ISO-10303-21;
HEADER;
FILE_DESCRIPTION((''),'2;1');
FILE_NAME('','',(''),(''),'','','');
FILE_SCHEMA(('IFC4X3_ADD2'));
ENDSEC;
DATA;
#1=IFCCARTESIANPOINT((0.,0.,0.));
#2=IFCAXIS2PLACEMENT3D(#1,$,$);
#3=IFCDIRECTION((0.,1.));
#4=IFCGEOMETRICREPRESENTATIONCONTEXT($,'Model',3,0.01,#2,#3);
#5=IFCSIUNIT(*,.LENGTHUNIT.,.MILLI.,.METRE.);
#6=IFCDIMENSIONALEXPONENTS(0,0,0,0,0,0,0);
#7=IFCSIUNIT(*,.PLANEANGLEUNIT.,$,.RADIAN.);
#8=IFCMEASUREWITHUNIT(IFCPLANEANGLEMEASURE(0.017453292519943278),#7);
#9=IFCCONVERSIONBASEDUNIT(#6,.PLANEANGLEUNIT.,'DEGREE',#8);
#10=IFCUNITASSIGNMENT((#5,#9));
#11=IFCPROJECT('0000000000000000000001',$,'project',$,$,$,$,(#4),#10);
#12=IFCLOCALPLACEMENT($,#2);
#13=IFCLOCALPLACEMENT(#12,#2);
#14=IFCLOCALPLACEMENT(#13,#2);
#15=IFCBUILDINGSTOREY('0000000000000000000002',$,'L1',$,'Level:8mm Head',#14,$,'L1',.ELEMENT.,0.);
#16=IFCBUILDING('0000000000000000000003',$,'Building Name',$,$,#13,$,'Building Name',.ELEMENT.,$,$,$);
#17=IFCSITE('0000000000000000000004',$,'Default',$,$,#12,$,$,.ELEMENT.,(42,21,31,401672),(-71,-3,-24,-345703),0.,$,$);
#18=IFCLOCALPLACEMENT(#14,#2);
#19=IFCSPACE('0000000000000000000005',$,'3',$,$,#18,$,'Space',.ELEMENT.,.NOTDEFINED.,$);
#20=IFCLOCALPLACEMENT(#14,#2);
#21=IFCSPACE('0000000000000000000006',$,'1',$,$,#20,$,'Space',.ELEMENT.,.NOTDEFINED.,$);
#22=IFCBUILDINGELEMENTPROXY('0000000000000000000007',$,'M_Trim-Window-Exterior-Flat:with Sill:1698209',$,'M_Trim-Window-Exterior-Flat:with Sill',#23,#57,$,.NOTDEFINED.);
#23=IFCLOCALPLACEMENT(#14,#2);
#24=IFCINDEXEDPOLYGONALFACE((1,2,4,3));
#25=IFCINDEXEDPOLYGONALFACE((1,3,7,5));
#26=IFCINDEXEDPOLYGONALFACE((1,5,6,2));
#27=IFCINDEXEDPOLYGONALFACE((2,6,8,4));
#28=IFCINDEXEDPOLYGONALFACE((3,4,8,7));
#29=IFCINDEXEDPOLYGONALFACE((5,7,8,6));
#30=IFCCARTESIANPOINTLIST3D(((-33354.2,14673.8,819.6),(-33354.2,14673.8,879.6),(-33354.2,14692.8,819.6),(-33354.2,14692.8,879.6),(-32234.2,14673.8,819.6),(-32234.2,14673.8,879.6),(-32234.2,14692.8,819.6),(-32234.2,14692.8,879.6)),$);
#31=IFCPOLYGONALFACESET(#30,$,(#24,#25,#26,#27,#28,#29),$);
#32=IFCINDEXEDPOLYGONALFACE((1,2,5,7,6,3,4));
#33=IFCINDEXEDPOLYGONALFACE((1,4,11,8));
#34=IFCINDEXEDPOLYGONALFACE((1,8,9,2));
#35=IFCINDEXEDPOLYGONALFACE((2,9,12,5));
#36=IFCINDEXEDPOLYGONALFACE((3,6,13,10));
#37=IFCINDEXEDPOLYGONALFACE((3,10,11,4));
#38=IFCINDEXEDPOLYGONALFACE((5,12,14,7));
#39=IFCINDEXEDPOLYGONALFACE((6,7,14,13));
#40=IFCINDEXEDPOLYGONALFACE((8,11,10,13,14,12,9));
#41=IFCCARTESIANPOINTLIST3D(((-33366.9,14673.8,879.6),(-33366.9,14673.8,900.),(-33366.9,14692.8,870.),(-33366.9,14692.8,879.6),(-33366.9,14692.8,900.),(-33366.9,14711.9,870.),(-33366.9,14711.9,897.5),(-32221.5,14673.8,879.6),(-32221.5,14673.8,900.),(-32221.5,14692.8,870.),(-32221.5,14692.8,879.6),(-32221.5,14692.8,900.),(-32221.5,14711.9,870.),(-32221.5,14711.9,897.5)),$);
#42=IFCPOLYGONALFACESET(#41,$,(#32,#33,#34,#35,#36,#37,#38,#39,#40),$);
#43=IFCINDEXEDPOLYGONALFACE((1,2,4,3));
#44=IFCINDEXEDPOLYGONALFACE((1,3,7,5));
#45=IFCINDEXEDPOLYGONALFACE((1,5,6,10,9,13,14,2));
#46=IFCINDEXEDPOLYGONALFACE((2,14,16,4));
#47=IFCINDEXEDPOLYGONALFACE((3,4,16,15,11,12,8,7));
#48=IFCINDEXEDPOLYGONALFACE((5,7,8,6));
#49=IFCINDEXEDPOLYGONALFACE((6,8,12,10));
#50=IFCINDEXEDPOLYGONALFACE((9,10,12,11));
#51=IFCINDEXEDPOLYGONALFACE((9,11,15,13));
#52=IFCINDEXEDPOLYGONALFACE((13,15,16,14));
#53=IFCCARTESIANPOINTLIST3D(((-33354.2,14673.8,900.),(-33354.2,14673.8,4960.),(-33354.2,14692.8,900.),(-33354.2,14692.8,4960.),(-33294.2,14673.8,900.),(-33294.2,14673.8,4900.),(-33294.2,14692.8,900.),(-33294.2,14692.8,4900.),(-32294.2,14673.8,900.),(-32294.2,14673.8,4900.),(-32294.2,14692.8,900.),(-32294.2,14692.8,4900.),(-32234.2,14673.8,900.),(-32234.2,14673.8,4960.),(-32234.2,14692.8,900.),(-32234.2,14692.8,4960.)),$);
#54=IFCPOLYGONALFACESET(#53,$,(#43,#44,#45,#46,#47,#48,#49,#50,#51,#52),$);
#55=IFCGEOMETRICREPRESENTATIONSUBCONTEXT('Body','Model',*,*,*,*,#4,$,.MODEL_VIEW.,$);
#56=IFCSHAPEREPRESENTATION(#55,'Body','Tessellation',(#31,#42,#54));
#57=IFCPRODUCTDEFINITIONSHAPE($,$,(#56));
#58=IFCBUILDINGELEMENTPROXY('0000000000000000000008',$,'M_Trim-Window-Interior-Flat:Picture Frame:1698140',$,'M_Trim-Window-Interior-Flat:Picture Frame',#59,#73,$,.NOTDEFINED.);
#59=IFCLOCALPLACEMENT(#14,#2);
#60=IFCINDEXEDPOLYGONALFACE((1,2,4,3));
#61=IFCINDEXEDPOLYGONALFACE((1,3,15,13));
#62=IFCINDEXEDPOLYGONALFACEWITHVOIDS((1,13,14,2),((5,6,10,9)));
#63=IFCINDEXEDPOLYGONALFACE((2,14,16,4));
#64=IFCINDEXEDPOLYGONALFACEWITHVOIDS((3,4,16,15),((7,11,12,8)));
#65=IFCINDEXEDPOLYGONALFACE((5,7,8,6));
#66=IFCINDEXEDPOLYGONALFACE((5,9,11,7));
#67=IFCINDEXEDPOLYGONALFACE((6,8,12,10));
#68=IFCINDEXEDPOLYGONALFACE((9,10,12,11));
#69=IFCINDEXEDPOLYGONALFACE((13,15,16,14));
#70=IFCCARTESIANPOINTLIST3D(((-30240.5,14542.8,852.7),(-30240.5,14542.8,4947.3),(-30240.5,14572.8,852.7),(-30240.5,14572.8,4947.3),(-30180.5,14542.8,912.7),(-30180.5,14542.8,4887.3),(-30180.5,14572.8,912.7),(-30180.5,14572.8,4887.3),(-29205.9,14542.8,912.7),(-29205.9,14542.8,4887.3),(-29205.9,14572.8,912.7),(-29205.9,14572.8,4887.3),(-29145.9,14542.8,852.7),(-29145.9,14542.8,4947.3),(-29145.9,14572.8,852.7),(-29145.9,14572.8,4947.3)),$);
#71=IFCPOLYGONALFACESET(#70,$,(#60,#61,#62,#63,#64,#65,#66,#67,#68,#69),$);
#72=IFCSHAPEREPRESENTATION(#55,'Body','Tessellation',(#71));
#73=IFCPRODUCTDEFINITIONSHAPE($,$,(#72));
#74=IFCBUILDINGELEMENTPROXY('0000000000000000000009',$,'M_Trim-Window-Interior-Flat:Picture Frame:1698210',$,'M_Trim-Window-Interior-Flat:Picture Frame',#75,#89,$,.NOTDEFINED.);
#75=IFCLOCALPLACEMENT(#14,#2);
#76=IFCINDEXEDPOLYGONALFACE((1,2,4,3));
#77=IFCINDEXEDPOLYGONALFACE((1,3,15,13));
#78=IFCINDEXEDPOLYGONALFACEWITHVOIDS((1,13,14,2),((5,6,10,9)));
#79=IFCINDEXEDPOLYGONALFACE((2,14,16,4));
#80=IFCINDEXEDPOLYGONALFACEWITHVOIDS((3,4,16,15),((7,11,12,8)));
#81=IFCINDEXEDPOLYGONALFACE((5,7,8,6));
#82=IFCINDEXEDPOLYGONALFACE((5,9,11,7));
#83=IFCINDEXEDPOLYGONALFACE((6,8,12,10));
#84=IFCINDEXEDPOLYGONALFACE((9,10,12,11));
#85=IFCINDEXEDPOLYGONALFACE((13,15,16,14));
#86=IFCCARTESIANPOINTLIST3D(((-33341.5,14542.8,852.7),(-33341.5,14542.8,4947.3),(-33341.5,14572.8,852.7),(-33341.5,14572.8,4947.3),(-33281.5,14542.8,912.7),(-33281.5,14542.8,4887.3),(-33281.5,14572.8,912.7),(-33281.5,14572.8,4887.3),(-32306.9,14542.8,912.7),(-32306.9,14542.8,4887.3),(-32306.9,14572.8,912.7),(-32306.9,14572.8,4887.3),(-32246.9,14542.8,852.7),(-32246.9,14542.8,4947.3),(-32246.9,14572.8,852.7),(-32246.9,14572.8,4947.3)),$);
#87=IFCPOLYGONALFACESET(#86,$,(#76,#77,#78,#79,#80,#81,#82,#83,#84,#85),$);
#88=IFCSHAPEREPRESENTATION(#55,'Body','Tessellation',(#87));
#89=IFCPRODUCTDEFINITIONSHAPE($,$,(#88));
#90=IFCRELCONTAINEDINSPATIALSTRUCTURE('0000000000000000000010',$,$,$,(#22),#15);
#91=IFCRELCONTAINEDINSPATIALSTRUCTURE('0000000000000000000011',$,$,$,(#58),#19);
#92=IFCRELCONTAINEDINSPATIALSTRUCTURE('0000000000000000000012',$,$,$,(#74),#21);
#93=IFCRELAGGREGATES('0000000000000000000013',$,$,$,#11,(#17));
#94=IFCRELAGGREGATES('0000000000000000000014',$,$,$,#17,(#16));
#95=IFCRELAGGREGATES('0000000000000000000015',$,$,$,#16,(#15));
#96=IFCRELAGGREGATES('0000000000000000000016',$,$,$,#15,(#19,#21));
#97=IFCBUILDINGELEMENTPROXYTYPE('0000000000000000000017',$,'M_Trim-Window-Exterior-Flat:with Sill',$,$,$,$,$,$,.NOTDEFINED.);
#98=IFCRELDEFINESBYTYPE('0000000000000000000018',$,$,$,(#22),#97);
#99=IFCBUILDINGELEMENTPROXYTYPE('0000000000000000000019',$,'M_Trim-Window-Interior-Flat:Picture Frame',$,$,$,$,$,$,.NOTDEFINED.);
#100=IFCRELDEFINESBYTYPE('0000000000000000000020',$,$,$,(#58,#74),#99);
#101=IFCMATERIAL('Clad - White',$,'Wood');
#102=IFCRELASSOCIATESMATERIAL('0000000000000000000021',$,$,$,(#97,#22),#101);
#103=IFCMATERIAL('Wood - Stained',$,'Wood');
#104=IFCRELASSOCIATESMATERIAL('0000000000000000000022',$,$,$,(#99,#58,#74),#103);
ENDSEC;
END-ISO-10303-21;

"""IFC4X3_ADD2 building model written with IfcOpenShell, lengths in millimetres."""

from ifc_helpers import new_model, entity, si_unit, converted_unit, direction, frame, frame_2d, origin, place, context, subcontext, project, spatial, polyline, rectangle, outline, extrude, source, transform, mapped, material, type_object, type_shapes, element, save


model = new_model("IFC4X3_ADD2")

# Units and contexts
model_context = context("Model", 3, precision=0.01, world=origin(), true_north=direction((0.0, 1.0)))
body_context = subcontext(model_context, "Body", "Model", "MODEL_VIEW")
ifc_project = project(units=[si_unit("LENGTHUNIT", "METRE", prefix="MILLI"), converted_unit("PLANEANGLEUNIT", "DEGREE", entity("IfcPlaneAngleMeasure", 0.017453292519943278), si_unit("PLANEANGLEUNIT", "RADIAN"), dimensions=[0, 0, 0, 0, 0, 0, 0])], contexts=[model_context])

# Site, building, storey
site_placement = place(None, origin())
site = spatial("IfcSite", under=ifc_project, at=site_placement, Name="Default", CompositionType="ELEMENT", RefLatitude=(42, 21, 31, 401672), RefLongitude=(-71, -3, -24, -345703), RefElevation=0.0)
building_placement = place(site_placement, origin())
building = spatial("IfcBuilding", under=site, at=building_placement, Name="Building Name", LongName="Building Name", CompositionType="ELEMENT")
storey_placement = place(building_placement, origin())
storey = spatial("IfcBuildingStorey", under=building, at=storey_placement, Name="L1", ObjectType="Level:8mm Head", LongName="L1", CompositionType="ELEMENT", Elevation=0.0)

# Building element proxy
ifc_material_1 = material(Name="Clad - White", Category="Wood")
ifc_material_2 = material(Name="Wood - Stained", Category="Wood")
building_element_proxy_type_1 = type_object("IfcBuildingElementProxyType", Name="M_Trim-Window-Exterior-Flat:with Sill", PredefinedType="NOTDEFINED", material=ifc_material_1)
shared_shape_1 = source(origin(), body_context, "Body", "SweptSolid", [
    extrude(rectangle(XDim=1120.0, YDim=60.0, at=frame_2d((0.0, 0.0), x_axis=(1.0, 0.0))), frame((0.0, -4050.4, 0.0), z_axis=(0.0, 0.0, 1.0), x_axis=(-1.0, 0.0, 0.0)), (0.0, 0.0, 1.0), 19.0),
    extrude(outline(polyline([(-19.0, -15.2), (0.0, -15.2), (0.0, -5.7), (19.0, -5.7), (19.0, 14.8), (0.0, 14.8), (-19.0, 12.3), (-19.0, -15.2)])), frame((-572.7, -4014.8, 19.0), z_axis=(1.0, 0.0, 0.0), x_axis=(0.0, 0.0, -1.0)), (0.0, 0.0, 1.0), 1145.4),
    extrude(outline(polyline([(-2045.0, -560.0), (2015.0, -560.0), (2015.0, -500.0), (-1985.0, -500.0), (-1985.0, 500.0), (2015.0, 500.0), (2015.0, 560.0), (-2045.0, 560.0), (-2045.0, -560.0)])), frame((0.0, -1985.0, 0.0), z_axis=(0.0, 0.0, 1.0), x_axis=(0.0, -1.0, 0.0)), (0.0, 0.0, 1.0), 19.0),
])
type_shapes(building_element_proxy_type_1, [shared_shape_1])
for number, where, z_axis, x_axis, name in (
    (1, (-32794.2, 14673.8, 4900.0), (0.0, 1.0, 0.0), (-1.0, 0.0, 0.0), "M_Trim-Window-Exterior-Flat:with Sill:1698209"),
):
    element("IfcBuildingElementProxy", number, at=place(storey_placement, frame(where, z_axis=z_axis, x_axis=x_axis)), inside=storey, type_object=building_element_proxy_type_1, material=ifc_material_1, Name=name, ObjectType="M_Trim-Window-Exterior-Flat:with Sill", PredefinedType="NOTDEFINED", context=body_context, shape_type="MappedRepresentation", body=[
        mapped(shared_shape_1, transform((0.0, 0.0, 0.0), scale=1.0)),
    ])

# Shared definitions
space_1_placement = place(storey_placement, origin())
space_1 = spatial("IfcSpace", under=storey, at=space_1_placement, Name="3", LongName="Space", CompositionType="ELEMENT", PredefinedType="NOTDEFINED")

# Building element proxy
building_element_proxy_type_2 = type_object("IfcBuildingElementProxyType", Name="M_Trim-Window-Interior-Flat:Picture Frame", PredefinedType="NOTDEFINED", material=ifc_material_2)
shared_shape_2 = source(origin(), body_context, "Body", "SweptSolid", [
    extrude(outline(polyline([(-547.3, -2047.3), (547.3, -2047.3), (547.3, 2047.3), (-547.3, 2047.3), (-547.3, -2047.3)]), holes=[polyline([(-487.3, -1987.3), (-487.3, 1987.3), (487.3, 1987.3), (487.3, -1987.3), (-487.3, -1987.3)])]), frame((0.0, -2000.0, 0.0), z_axis=(0.0, 0.0, 1.0), x_axis=(-1.0, 0.0, 0.0)), (0.0, 0.0, 1.0), 30.0),
])
type_shapes(building_element_proxy_type_2, [shared_shape_2])
proxy_1_placement = place(space_1_placement, frame((-29693.2, 14572.8, 4900.0), z_axis=(0.0, -1.0, 0.0), x_axis=(1.0, 0.0, 0.0)))
element("IfcBuildingElementProxy", 2, at=proxy_1_placement, inside=space_1, type_object=building_element_proxy_type_2, material=ifc_material_2, Name="M_Trim-Window-Interior-Flat:Picture Frame:1698140", ObjectType="M_Trim-Window-Interior-Flat:Picture Frame", PredefinedType="NOTDEFINED", context=body_context, shape_type="MappedRepresentation", body=[
    mapped(shared_shape_2, transform((0.0, 0.0, 0.0), scale=1.0)),
])

# Shared definitions
space_2_placement = place(storey_placement, origin())
space_2 = spatial("IfcSpace", under=storey, at=space_2_placement, Name="1", LongName="Space", CompositionType="ELEMENT", PredefinedType="NOTDEFINED")

# Building element proxy
proxy_2_placement = place(space_2_placement, frame((-32794.2, 14572.8, 4900.0), z_axis=(0.0, -1.0, 0.0), x_axis=(1.0, 0.0, 0.0)))
element("IfcBuildingElementProxy", 3, at=proxy_2_placement, inside=space_2, type_object=building_element_proxy_type_2, material=ifc_material_2, Name="M_Trim-Window-Interior-Flat:Picture Frame:1698210", ObjectType="M_Trim-Window-Interior-Flat:Picture Frame", PredefinedType="NOTDEFINED", context=body_context, shape_type="MappedRepresentation", body=[
    mapped(shared_shape_2, transform((0.0, 0.0, 0.0), scale=1.0)),
])

save(model, "model.ifc")
